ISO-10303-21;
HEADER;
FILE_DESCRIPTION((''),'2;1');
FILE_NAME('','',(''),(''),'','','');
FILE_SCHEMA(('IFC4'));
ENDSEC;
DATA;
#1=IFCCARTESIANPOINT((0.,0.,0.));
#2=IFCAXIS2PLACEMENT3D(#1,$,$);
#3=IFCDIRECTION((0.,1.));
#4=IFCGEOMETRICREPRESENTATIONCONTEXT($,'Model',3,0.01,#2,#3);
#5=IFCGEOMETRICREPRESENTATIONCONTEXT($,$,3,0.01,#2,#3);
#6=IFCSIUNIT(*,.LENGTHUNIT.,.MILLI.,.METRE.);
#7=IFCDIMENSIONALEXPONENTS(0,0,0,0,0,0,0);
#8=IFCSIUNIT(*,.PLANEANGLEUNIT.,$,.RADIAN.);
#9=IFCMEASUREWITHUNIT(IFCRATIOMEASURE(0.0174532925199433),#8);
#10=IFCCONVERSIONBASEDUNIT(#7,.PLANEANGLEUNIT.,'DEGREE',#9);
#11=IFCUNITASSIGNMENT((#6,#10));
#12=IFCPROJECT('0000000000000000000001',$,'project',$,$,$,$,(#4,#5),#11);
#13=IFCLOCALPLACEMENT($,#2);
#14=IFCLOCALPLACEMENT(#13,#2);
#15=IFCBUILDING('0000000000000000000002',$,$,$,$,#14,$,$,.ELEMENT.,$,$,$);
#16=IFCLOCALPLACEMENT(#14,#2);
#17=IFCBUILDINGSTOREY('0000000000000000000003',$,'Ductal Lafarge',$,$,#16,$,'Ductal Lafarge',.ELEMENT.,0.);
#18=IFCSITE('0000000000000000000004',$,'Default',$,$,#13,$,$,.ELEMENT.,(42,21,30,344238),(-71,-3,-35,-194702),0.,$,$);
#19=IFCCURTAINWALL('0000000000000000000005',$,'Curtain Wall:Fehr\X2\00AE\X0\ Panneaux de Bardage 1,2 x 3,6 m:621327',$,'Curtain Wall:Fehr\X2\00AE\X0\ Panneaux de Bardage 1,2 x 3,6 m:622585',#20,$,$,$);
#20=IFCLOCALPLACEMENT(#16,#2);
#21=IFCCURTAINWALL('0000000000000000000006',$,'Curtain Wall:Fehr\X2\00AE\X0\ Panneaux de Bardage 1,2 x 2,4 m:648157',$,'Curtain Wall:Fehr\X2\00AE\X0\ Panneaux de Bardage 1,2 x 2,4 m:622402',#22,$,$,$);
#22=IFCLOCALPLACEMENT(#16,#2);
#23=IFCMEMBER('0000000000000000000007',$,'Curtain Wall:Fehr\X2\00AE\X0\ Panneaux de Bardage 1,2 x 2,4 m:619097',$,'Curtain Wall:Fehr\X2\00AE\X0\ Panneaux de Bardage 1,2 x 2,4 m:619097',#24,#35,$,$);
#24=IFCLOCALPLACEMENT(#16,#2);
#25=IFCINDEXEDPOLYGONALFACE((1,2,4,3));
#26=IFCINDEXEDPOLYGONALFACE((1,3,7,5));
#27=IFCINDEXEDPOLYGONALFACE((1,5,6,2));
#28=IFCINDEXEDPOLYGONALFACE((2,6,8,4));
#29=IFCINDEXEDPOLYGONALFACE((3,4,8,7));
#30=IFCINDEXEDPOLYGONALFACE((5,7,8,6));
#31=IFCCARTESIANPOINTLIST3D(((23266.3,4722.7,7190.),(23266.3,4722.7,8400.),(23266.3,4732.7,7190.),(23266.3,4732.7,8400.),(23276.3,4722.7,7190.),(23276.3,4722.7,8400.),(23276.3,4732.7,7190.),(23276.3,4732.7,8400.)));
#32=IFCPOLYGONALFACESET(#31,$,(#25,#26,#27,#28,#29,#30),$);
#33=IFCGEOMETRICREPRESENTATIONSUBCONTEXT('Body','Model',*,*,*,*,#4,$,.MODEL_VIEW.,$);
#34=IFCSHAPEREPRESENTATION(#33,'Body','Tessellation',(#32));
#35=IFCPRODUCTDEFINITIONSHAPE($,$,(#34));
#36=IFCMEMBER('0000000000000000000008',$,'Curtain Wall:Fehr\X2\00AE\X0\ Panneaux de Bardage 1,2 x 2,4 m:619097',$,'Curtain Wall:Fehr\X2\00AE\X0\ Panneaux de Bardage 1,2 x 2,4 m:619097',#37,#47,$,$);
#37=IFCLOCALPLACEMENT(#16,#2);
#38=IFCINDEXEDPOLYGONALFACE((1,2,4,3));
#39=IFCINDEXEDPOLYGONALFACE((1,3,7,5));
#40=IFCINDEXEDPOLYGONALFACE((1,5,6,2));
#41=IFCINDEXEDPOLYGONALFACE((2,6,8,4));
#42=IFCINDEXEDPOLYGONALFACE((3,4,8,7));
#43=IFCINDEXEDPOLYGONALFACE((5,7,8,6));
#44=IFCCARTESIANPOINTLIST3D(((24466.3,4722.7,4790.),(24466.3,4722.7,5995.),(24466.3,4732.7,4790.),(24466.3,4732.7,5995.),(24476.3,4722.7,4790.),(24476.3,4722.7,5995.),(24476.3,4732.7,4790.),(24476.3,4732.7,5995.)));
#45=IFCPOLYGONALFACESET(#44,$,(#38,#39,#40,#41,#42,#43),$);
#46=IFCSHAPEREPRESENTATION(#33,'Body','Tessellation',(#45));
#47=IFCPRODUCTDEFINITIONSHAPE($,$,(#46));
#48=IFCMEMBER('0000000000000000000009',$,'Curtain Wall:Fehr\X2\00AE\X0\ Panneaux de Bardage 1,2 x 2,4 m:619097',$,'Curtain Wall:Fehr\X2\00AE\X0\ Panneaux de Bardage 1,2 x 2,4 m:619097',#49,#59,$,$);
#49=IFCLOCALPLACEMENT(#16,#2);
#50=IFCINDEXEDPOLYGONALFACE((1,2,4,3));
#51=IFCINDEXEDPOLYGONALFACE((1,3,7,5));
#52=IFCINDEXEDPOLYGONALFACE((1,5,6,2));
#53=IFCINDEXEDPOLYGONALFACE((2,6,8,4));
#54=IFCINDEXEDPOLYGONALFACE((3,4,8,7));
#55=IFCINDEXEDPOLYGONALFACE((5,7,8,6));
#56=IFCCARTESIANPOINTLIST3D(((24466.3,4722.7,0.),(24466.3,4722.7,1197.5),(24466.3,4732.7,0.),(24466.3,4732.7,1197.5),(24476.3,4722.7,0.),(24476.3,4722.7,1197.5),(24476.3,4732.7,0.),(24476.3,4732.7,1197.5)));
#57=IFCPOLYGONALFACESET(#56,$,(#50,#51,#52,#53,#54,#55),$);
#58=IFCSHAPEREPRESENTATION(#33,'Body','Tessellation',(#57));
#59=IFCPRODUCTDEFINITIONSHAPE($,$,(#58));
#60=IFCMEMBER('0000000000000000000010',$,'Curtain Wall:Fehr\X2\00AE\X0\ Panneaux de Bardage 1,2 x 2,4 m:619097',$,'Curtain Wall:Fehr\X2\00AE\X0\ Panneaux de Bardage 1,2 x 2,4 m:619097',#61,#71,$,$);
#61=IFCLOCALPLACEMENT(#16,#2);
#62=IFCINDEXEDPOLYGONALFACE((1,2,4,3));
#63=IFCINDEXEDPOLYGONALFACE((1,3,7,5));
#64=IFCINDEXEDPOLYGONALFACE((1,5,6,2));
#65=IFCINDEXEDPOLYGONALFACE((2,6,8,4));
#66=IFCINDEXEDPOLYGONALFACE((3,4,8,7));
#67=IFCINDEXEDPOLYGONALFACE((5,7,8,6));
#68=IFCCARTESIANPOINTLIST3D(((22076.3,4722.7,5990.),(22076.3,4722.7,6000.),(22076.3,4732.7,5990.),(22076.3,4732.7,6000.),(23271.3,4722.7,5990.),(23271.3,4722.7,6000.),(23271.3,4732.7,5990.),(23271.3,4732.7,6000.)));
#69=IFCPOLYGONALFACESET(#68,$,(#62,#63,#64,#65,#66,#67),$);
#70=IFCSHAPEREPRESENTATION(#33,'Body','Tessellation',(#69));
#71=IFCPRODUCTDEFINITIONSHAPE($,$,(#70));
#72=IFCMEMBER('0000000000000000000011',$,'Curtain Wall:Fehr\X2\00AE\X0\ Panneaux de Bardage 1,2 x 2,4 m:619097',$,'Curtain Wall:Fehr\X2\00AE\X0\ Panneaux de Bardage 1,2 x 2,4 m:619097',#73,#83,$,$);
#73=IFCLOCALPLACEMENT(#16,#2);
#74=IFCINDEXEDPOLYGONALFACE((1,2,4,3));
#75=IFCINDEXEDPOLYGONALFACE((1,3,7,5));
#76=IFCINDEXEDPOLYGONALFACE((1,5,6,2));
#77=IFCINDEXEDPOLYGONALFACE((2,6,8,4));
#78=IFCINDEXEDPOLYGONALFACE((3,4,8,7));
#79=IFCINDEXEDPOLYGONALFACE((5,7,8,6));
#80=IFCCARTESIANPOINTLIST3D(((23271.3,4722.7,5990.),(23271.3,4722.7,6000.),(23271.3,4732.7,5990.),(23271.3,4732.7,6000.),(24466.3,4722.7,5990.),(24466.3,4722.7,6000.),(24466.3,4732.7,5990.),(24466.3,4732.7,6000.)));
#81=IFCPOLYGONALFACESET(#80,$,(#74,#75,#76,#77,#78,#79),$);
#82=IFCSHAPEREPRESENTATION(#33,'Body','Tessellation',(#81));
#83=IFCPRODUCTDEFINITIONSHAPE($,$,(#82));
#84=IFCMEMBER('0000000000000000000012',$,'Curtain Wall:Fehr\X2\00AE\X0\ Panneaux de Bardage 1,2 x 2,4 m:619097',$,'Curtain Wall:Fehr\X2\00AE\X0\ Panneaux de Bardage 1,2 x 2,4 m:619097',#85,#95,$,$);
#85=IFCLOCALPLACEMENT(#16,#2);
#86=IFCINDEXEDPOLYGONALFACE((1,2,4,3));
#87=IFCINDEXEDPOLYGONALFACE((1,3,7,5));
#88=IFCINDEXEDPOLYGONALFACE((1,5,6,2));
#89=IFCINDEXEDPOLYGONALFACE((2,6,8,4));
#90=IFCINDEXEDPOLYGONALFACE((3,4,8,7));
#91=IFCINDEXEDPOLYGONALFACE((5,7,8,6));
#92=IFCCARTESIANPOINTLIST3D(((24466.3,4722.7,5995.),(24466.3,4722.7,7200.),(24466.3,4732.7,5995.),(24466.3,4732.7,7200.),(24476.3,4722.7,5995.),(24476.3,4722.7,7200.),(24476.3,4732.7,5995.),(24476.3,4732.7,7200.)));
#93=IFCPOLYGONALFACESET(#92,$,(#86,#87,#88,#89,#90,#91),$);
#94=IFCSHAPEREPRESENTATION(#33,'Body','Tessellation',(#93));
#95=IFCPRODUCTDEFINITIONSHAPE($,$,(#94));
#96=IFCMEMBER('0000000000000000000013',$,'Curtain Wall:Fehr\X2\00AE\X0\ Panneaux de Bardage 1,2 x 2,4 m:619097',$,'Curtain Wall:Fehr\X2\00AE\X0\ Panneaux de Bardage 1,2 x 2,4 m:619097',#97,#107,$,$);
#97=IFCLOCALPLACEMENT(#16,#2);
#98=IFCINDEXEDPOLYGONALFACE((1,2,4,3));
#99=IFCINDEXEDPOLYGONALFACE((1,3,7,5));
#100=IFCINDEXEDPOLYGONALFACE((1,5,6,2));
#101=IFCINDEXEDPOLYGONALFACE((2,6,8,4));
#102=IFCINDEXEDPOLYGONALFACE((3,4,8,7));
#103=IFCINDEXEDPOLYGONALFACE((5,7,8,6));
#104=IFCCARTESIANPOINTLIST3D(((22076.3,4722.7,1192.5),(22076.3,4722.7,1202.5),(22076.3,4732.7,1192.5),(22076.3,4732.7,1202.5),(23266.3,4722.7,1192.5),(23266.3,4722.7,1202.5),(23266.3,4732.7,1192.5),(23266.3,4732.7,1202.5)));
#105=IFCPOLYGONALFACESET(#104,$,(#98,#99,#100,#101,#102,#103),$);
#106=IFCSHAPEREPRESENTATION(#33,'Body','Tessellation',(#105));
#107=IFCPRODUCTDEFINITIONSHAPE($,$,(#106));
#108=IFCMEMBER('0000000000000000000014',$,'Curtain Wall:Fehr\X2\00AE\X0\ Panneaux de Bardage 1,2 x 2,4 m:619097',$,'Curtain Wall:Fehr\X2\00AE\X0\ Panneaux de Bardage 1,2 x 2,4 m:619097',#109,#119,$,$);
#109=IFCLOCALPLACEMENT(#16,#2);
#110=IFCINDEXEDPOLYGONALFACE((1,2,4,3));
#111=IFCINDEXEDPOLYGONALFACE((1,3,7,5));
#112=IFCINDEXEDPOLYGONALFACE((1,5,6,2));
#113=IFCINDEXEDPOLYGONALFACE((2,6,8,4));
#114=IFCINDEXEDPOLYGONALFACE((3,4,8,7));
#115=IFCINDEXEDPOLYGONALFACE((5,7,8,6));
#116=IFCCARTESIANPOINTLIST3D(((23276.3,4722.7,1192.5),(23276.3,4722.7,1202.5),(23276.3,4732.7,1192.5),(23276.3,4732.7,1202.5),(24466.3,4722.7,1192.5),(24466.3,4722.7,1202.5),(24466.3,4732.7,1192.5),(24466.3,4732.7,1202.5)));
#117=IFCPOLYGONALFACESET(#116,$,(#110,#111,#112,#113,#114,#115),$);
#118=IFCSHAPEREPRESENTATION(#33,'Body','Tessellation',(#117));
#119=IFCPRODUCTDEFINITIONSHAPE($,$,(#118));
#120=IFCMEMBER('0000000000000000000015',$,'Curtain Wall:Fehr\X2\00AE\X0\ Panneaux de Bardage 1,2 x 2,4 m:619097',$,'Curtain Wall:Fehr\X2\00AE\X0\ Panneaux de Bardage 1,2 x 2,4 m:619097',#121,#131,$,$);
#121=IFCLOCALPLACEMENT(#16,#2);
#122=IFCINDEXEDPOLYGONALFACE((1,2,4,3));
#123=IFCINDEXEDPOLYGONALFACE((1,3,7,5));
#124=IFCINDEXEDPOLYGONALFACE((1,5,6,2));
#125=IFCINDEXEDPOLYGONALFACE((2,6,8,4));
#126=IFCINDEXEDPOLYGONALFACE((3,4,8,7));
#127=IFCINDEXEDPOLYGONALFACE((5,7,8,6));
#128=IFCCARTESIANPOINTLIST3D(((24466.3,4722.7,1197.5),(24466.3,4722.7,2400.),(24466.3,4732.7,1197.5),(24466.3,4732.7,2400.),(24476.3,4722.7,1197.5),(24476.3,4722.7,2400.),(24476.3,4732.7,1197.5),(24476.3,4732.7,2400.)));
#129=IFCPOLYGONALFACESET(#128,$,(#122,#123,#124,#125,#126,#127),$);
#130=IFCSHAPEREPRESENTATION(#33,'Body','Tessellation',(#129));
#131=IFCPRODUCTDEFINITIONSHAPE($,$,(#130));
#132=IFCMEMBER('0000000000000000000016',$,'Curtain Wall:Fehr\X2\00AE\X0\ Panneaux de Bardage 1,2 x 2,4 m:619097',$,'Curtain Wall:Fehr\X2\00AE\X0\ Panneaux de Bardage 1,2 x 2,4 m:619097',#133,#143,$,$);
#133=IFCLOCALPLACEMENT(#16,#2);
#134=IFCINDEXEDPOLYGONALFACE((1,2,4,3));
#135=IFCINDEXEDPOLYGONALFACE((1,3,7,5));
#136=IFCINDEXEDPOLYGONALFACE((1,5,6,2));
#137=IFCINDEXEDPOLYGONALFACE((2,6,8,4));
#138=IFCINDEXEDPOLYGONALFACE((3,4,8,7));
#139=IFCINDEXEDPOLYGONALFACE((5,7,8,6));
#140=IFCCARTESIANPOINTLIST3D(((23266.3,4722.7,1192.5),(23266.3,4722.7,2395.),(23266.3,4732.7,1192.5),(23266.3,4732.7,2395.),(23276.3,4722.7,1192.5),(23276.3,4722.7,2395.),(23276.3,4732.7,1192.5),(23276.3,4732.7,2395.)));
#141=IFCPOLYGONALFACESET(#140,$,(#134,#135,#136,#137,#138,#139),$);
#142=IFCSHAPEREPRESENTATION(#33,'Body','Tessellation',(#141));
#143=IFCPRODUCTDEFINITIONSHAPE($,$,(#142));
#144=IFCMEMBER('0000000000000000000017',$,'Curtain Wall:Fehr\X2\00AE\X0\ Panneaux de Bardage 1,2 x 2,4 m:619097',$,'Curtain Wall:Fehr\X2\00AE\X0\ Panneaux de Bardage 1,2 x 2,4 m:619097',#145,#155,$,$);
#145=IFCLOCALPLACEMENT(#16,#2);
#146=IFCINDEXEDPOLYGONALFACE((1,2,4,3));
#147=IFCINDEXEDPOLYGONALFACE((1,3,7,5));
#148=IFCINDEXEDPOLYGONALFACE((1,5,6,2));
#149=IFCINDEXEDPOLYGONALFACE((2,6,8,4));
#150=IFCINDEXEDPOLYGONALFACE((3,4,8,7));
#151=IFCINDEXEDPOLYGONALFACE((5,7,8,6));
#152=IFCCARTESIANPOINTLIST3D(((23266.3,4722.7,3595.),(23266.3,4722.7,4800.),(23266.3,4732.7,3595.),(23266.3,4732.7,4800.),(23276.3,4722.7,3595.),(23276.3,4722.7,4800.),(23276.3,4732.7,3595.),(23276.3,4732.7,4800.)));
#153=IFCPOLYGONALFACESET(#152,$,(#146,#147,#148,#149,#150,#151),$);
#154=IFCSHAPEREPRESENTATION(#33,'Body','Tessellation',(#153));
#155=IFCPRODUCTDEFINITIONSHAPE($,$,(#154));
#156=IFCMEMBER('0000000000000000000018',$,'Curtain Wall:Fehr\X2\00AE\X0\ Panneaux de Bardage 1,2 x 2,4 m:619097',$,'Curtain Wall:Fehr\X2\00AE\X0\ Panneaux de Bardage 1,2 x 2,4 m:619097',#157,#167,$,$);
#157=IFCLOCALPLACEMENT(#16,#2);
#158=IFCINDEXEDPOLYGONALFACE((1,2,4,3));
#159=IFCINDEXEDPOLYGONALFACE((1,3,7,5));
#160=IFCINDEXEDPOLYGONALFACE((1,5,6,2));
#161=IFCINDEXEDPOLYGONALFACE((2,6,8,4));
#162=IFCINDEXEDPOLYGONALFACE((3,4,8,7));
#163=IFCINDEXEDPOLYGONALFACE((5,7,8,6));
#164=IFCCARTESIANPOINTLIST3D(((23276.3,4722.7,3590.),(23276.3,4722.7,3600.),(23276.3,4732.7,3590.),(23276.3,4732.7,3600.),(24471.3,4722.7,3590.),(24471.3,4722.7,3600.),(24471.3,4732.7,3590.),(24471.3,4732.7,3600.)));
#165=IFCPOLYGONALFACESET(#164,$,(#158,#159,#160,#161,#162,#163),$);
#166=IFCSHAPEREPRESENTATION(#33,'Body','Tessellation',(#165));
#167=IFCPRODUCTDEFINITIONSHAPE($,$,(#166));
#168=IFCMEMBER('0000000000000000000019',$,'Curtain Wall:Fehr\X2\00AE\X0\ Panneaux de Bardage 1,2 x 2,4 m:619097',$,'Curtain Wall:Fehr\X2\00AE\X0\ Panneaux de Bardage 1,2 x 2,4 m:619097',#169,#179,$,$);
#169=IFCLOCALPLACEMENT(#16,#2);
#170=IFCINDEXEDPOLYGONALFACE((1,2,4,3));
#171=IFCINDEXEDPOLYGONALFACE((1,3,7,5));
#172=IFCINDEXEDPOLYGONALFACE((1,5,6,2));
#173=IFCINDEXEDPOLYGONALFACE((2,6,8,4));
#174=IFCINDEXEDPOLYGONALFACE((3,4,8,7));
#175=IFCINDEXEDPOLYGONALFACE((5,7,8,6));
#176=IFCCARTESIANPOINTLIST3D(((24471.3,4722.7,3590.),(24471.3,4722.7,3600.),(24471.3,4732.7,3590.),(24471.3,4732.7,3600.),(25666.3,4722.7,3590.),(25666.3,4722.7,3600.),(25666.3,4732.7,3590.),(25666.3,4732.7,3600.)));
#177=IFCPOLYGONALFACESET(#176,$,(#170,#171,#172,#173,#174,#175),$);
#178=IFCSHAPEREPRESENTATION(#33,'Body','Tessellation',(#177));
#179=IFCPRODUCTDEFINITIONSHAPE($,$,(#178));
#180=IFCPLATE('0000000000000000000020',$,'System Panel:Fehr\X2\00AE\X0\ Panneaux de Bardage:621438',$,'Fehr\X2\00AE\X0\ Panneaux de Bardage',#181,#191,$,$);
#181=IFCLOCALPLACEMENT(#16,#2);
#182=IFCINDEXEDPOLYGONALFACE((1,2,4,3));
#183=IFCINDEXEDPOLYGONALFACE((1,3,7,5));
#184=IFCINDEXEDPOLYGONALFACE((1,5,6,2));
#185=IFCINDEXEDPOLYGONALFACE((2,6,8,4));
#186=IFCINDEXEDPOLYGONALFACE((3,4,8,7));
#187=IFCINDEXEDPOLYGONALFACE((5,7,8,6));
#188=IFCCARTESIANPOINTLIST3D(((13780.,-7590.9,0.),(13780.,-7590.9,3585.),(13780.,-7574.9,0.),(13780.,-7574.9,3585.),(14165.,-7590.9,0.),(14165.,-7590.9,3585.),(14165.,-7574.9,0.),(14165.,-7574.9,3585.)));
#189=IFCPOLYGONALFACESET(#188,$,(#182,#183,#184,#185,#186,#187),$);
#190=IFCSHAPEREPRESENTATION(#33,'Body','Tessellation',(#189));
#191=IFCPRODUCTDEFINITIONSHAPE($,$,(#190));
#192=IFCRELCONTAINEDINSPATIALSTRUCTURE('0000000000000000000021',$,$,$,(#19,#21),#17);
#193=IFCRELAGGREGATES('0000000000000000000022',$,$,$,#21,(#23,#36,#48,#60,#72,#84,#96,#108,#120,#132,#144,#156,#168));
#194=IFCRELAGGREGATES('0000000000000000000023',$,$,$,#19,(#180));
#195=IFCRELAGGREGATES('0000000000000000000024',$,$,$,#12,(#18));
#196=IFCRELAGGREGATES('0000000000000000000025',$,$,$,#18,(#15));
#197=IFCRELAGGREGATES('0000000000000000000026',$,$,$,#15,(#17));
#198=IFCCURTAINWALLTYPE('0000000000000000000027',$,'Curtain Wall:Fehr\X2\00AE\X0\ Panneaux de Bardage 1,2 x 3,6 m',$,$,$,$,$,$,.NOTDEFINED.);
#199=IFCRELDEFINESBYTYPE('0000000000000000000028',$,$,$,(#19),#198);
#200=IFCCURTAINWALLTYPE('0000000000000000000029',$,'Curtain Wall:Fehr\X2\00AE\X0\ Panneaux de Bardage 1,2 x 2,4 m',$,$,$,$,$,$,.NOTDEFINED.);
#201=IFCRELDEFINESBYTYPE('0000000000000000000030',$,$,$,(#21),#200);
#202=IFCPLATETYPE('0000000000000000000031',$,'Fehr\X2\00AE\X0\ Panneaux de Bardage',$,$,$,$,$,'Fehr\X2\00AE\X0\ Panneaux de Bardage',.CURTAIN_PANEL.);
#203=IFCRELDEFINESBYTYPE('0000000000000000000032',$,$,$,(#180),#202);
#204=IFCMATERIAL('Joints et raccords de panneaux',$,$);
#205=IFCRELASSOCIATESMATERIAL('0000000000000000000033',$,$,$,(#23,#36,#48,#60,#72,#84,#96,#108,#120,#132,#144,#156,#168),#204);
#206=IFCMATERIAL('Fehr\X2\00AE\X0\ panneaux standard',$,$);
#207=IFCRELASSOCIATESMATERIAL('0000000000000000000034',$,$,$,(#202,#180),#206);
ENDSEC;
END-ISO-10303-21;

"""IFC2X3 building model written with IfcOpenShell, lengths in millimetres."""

from ifc_helpers import new_model, entity, si_unit, converted_unit, direction, frame, frame_2d, origin, origin_2d_with_axis, place, context, subcontext, project, spatial, rectangle, extrude, source, transform, mapped, material, type_object, type_shapes, element, aggregate, save


model = new_model("IFC2X3")

# Units and contexts
model_context = context("Model", 3, precision=0.01, world=origin(), true_north=direction((0.0, 1.0)))
context_of_model = context(None, 3, precision=0.01, world=origin(), true_north=direction((0.0, 1.0)))
body_context = subcontext(model_context, "Body", "Model", "MODEL_VIEW")
ifc_project = project(units=[si_unit("LENGTHUNIT", "METRE", prefix="MILLI"), converted_unit("PLANEANGLEUNIT", "DEGREE", entity("IfcRatioMeasure", 0.0174532925199433), si_unit("PLANEANGLEUNIT", "RADIAN"), dimensions=[0, 0, 0, 0, 0, 0, 0])], contexts=[model_context, context_of_model])

# Site, building, storey
site_placement = place(None, origin())
site = spatial("IfcSite", under=ifc_project, at=site_placement, Name="Default", CompositionType="ELEMENT", RefLatitude=(42, 21, 30, 344238), RefLongitude=(-71, -3, -35, -194702), RefElevation=0.0)
building_placement = place(site_placement, origin())
building = spatial("IfcBuilding", under=site, at=building_placement, CompositionType="ELEMENT")
storey_placement = place(building_placement, origin())
storey = spatial("IfcBuildingStorey", under=building, at=storey_placement, Name="Ductal Lafarge", LongName="Ductal Lafarge", CompositionType="ELEMENT", Elevation=0.0)

# Curtain walls, members
curtain_wall_type_1 = type_object("IfcCurtainWallType", Name="Curtain Wall:Fehr® Panneaux de Bardage 1,2 x 3,6 m", PredefinedType="NOTDEFINED")
curtain_wall_1_placement = place(storey_placement, origin())
curtain_wall_1 = element("IfcCurtainWall", 1, at=curtain_wall_1_placement, inside=storey, type_object=curtain_wall_type_1, Name="Curtain Wall:Fehr® Panneaux de Bardage 1,2 x 3,6 m:621327", ObjectType="Curtain Wall:Fehr® Panneaux de Bardage 1,2 x 3,6 m:622585")
ifc_material_1 = material(Name="Joints et raccords de panneaux")
curtain_wall_type_2 = type_object("IfcCurtainWallType", Name="Curtain Wall:Fehr® Panneaux de Bardage 1,2 x 2,4 m", PredefinedType="NOTDEFINED")
curtain_wall_2_placement = place(storey_placement, origin())
curtain_wall_2 = element("IfcCurtainWall", 2, at=curtain_wall_2_placement, inside=storey, type_object=curtain_wall_type_2, Name="Curtain Wall:Fehr® Panneaux de Bardage 1,2 x 2,4 m:648157", ObjectType="Curtain Wall:Fehr® Panneaux de Bardage 1,2 x 2,4 m:622402")
member_1_placement = place(curtain_wall_2_placement, frame((23266.3, 4722.7, 7190.0)))
member_1 = element("IfcMember", 3, at=member_1_placement, material=ifc_material_1, Name="Curtain Wall:Fehr® Panneaux de Bardage 1,2 x 2,4 m:619097", ObjectType="Curtain Wall:Fehr® Panneaux de Bardage 1,2 x 2,4 m:619097", context=body_context, shape_type="SweptSolid", body=[
    extrude(rectangle(XDim=10.0, YDim=10.0, at=origin_2d_with_axis()), frame((5.0, 5.0, 0.0), z_axis=(0.0, 0.0, 1.0), x_axis=(0.0, 1.0, 0.0)), (0.0, 0.0, 1.0), 1210.0),
])
member_2_placement = place(curtain_wall_2_placement, frame((24466.3, 4722.7, 4790.0)))
member_2 = element("IfcMember", 4, at=member_2_placement, material=ifc_material_1, Name="Curtain Wall:Fehr® Panneaux de Bardage 1,2 x 2,4 m:619097", ObjectType="Curtain Wall:Fehr® Panneaux de Bardage 1,2 x 2,4 m:619097", context=body_context, shape_type="SweptSolid", body=[
    extrude(rectangle(XDim=10.0, YDim=10.0, at=origin_2d_with_axis()), frame((5.0, 5.0, 0.0), z_axis=(0.0, 0.0, 1.0), x_axis=(0.0, 1.0, 0.0)), (0.0, 0.0, 1.0), 1205.0),
])
member_3_placement = place(curtain_wall_2_placement, frame((24466.3, 4722.7, 0.0)))
member_3 = element("IfcMember", 5, at=member_3_placement, material=ifc_material_1, Name="Curtain Wall:Fehr® Panneaux de Bardage 1,2 x 2,4 m:619097", ObjectType="Curtain Wall:Fehr® Panneaux de Bardage 1,2 x 2,4 m:619097", context=body_context, shape_type="SweptSolid", body=[
    extrude(rectangle(XDim=10.0, YDim=10.0, at=frame_2d((0.0, 0.0), x_axis=(1.0, 0.0))), frame((5.0, 5.0, 0.0), z_axis=(0.0, 0.0, 1.0), x_axis=(0.0, 1.0, 0.0)), (0.0, 0.0, 1.0), 1197.5),
])
member_4_placement = place(curtain_wall_2_placement, frame((22076.3, 4722.7, 5990.0)))
member_4 = element("IfcMember", 6, at=member_4_placement, material=ifc_material_1, Name="Curtain Wall:Fehr® Panneaux de Bardage 1,2 x 2,4 m:619097", ObjectType="Curtain Wall:Fehr® Panneaux de Bardage 1,2 x 2,4 m:619097", context=body_context, shape_type="SweptSolid", body=[
    extrude(rectangle(XDim=1195.0, YDim=10.0, at=frame_2d((0.0, 0.0), x_axis=(1.0, 0.0))), frame((597.5, 5.0, 0.0), z_axis=(0.0, 0.0, 1.0), x_axis=(-1.0, 0.0, 0.0)), (0.0, 0.0, 1.0), 10.0),
])
member_5_placement = place(curtain_wall_2_placement, frame((23271.3, 4722.7, 5990.0)))
member_5 = element("IfcMember", 7, at=member_5_placement, material=ifc_material_1, Name="Curtain Wall:Fehr® Panneaux de Bardage 1,2 x 2,4 m:619097", ObjectType="Curtain Wall:Fehr® Panneaux de Bardage 1,2 x 2,4 m:619097", context=body_context, shape_type="SweptSolid", body=[
    extrude(rectangle(XDim=1195.0, YDim=10.0, at=frame_2d((0.0, 0.0), x_axis=(1.0, 0.0))), frame((597.5, 5.0, 0.0), z_axis=(0.0, 0.0, 1.0), x_axis=(-1.0, 0.0, 0.0)), (0.0, 0.0, 1.0), 10.0),
])
member_6_placement = place(curtain_wall_2_placement, frame((24466.3, 4722.7, 5995.0)))
member_6 = element("IfcMember", 8, at=member_6_placement, material=ifc_material_1, Name="Curtain Wall:Fehr® Panneaux de Bardage 1,2 x 2,4 m:619097", ObjectType="Curtain Wall:Fehr® Panneaux de Bardage 1,2 x 2,4 m:619097", context=body_context, shape_type="SweptSolid", body=[
    extrude(rectangle(XDim=10.0, YDim=10.0, at=origin_2d_with_axis()), frame((5.0, 5.0, 0.0), z_axis=(0.0, 0.0, 1.0), x_axis=(0.0, 1.0, 0.0)), (0.0, 0.0, 1.0), 1205.0),
])
member_7_placement = place(curtain_wall_2_placement, frame((22076.3, 4722.7, 1192.5)))
member_7 = element("IfcMember", 9, at=member_7_placement, material=ifc_material_1, Name="Curtain Wall:Fehr® Panneaux de Bardage 1,2 x 2,4 m:619097", ObjectType="Curtain Wall:Fehr® Panneaux de Bardage 1,2 x 2,4 m:619097", context=body_context, shape_type="SweptSolid", body=[
    extrude(rectangle(XDim=1190.0, YDim=10.0, at=frame_2d((0.0, 0.0), x_axis=(1.0, 0.0))), frame((595.0, 5.0, 0.0), z_axis=(0.0, 0.0, 1.0), x_axis=(-1.0, 0.0, 0.0)), (0.0, 0.0, 1.0), 10.0),
])
member_8_placement = place(curtain_wall_2_placement, frame((23276.3, 4722.7, 1192.5)))
member_8 = element("IfcMember", 10, at=member_8_placement, material=ifc_material_1, Name="Curtain Wall:Fehr® Panneaux de Bardage 1,2 x 2,4 m:619097", ObjectType="Curtain Wall:Fehr® Panneaux de Bardage 1,2 x 2,4 m:619097", context=body_context, shape_type="SweptSolid", body=[
    extrude(rectangle(XDim=1190.0, YDim=10.0, at=frame_2d((0.0, 0.0), x_axis=(1.0, 0.0))), frame((595.0, 5.0, 0.0), z_axis=(0.0, 0.0, 1.0), x_axis=(-1.0, 0.0, 0.0)), (0.0, 0.0, 1.0), 10.0),
])
member_9_placement = place(curtain_wall_2_placement, frame((24466.3, 4722.7, 1197.5)))
member_9 = element("IfcMember", 11, at=member_9_placement, material=ifc_material_1, Name="Curtain Wall:Fehr® Panneaux de Bardage 1,2 x 2,4 m:619097", ObjectType="Curtain Wall:Fehr® Panneaux de Bardage 1,2 x 2,4 m:619097", context=body_context, shape_type="SweptSolid", body=[
    extrude(rectangle(XDim=10.0, YDim=10.0, at=origin_2d_with_axis()), frame((5.0, 5.0, 0.0), z_axis=(0.0, 0.0, 1.0), x_axis=(0.0, 1.0, 0.0)), (0.0, 0.0, 1.0), 1202.5),
])
member_10_placement = place(curtain_wall_2_placement, frame((23266.3, 4722.7, 1192.5)))
member_10 = element("IfcMember", 12, at=member_10_placement, material=ifc_material_1, Name="Curtain Wall:Fehr® Panneaux de Bardage 1,2 x 2,4 m:619097", ObjectType="Curtain Wall:Fehr® Panneaux de Bardage 1,2 x 2,4 m:619097", context=body_context, shape_type="SweptSolid", body=[
    extrude(rectangle(XDim=10.0, YDim=10.0, at=frame_2d((0.0, 0.0), x_axis=(1.0, 0.0))), frame((5.0, 5.0, 0.0), z_axis=(0.0, 0.0, 1.0), x_axis=(0.0, 1.0, 0.0)), (0.0, 0.0, 1.0), 1202.5),
])
member_11_placement = place(curtain_wall_2_placement, frame((23266.3, 4722.7, 3595.0)))
member_11 = element("IfcMember", 13, at=member_11_placement, material=ifc_material_1, Name="Curtain Wall:Fehr® Panneaux de Bardage 1,2 x 2,4 m:619097", ObjectType="Curtain Wall:Fehr® Panneaux de Bardage 1,2 x 2,4 m:619097", context=body_context, shape_type="SweptSolid", body=[
    extrude(rectangle(XDim=10.0, YDim=10.0, at=origin_2d_with_axis()), frame((5.0, 5.0, 0.0), z_axis=(0.0, 0.0, 1.0), x_axis=(0.0, 1.0, 0.0)), (0.0, 0.0, 1.0), 1205.0),
])
member_12_placement = place(curtain_wall_2_placement, frame((23276.3, 4722.7, 3590.0)))
member_12 = element("IfcMember", 14, at=member_12_placement, material=ifc_material_1, Name="Curtain Wall:Fehr® Panneaux de Bardage 1,2 x 2,4 m:619097", ObjectType="Curtain Wall:Fehr® Panneaux de Bardage 1,2 x 2,4 m:619097", context=body_context, shape_type="SweptSolid", body=[
    extrude(rectangle(XDim=1195.0, YDim=10.0, at=frame_2d((0.0, 0.0), x_axis=(1.0, 0.0))), frame((597.5, 5.0, 0.0), z_axis=(0.0, 0.0, 1.0), x_axis=(-1.0, 0.0, 0.0)), (0.0, 0.0, 1.0), 10.0),
])
member_13_placement = place(curtain_wall_2_placement, frame((24471.3, 4722.7, 3590.0)))
member_13 = element("IfcMember", 15, at=member_13_placement, material=ifc_material_1, Name="Curtain Wall:Fehr® Panneaux de Bardage 1,2 x 2,4 m:619097", ObjectType="Curtain Wall:Fehr® Panneaux de Bardage 1,2 x 2,4 m:619097", context=body_context, shape_type="SweptSolid", body=[
    extrude(rectangle(XDim=1195.0, YDim=10.0, at=frame_2d((0.0, 0.0), x_axis=(1.0, 0.0))), frame((597.5, 5.0, 0.0), z_axis=(0.0, 0.0, 1.0), x_axis=(-1.0, 0.0, 0.0)), (0.0, 0.0, 1.0), 10.0),
])
aggregate(curtain_wall_2, [member_1, member_2, member_3, member_4, member_5, member_6, member_7, member_8, member_9, member_10, member_11, member_12, member_13])

# Plate
ifc_material_2 = material(Name="Fehr® panneaux standard")
plate_type_1 = type_object("IfcPlateType", Name="Fehr® Panneaux de Bardage", ElementType="Fehr® Panneaux de Bardage", PredefinedType="CURTAIN_PANEL", material=ifc_material_2)
shared_shape_1 = source(origin(), body_context, "Body", "SweptSolid", [
    extrude(rectangle(XDim=16.0, YDim=385.0, at=origin_2d_with_axis()), frame((0.0, 0.0, 0.0), z_axis=(0.0, 0.0, 1.0), x_axis=(0.0, 1.0, 0.0)), (0.0, 0.0, 1.0), 3585.0),
])
type_shapes(plate_type_1, [shared_shape_1])
plate_1_placement = place(curtain_wall_1_placement, frame((13972.5, -7582.9, 0.0)))
plate_1 = element("IfcPlate", 16, at=plate_1_placement, type_object=plate_type_1, material=ifc_material_2, Name="System Panel:Fehr® Panneaux de Bardage:621438", ObjectType="Fehr® Panneaux de Bardage", context=body_context, shape_type="MappedRepresentation", body=[
    mapped(shared_shape_1, transform((0.0, 0.0, 0.0), scale=1.0)),
])
aggregate(curtain_wall_1, [plate_1])

save(model, "model.ifc")
